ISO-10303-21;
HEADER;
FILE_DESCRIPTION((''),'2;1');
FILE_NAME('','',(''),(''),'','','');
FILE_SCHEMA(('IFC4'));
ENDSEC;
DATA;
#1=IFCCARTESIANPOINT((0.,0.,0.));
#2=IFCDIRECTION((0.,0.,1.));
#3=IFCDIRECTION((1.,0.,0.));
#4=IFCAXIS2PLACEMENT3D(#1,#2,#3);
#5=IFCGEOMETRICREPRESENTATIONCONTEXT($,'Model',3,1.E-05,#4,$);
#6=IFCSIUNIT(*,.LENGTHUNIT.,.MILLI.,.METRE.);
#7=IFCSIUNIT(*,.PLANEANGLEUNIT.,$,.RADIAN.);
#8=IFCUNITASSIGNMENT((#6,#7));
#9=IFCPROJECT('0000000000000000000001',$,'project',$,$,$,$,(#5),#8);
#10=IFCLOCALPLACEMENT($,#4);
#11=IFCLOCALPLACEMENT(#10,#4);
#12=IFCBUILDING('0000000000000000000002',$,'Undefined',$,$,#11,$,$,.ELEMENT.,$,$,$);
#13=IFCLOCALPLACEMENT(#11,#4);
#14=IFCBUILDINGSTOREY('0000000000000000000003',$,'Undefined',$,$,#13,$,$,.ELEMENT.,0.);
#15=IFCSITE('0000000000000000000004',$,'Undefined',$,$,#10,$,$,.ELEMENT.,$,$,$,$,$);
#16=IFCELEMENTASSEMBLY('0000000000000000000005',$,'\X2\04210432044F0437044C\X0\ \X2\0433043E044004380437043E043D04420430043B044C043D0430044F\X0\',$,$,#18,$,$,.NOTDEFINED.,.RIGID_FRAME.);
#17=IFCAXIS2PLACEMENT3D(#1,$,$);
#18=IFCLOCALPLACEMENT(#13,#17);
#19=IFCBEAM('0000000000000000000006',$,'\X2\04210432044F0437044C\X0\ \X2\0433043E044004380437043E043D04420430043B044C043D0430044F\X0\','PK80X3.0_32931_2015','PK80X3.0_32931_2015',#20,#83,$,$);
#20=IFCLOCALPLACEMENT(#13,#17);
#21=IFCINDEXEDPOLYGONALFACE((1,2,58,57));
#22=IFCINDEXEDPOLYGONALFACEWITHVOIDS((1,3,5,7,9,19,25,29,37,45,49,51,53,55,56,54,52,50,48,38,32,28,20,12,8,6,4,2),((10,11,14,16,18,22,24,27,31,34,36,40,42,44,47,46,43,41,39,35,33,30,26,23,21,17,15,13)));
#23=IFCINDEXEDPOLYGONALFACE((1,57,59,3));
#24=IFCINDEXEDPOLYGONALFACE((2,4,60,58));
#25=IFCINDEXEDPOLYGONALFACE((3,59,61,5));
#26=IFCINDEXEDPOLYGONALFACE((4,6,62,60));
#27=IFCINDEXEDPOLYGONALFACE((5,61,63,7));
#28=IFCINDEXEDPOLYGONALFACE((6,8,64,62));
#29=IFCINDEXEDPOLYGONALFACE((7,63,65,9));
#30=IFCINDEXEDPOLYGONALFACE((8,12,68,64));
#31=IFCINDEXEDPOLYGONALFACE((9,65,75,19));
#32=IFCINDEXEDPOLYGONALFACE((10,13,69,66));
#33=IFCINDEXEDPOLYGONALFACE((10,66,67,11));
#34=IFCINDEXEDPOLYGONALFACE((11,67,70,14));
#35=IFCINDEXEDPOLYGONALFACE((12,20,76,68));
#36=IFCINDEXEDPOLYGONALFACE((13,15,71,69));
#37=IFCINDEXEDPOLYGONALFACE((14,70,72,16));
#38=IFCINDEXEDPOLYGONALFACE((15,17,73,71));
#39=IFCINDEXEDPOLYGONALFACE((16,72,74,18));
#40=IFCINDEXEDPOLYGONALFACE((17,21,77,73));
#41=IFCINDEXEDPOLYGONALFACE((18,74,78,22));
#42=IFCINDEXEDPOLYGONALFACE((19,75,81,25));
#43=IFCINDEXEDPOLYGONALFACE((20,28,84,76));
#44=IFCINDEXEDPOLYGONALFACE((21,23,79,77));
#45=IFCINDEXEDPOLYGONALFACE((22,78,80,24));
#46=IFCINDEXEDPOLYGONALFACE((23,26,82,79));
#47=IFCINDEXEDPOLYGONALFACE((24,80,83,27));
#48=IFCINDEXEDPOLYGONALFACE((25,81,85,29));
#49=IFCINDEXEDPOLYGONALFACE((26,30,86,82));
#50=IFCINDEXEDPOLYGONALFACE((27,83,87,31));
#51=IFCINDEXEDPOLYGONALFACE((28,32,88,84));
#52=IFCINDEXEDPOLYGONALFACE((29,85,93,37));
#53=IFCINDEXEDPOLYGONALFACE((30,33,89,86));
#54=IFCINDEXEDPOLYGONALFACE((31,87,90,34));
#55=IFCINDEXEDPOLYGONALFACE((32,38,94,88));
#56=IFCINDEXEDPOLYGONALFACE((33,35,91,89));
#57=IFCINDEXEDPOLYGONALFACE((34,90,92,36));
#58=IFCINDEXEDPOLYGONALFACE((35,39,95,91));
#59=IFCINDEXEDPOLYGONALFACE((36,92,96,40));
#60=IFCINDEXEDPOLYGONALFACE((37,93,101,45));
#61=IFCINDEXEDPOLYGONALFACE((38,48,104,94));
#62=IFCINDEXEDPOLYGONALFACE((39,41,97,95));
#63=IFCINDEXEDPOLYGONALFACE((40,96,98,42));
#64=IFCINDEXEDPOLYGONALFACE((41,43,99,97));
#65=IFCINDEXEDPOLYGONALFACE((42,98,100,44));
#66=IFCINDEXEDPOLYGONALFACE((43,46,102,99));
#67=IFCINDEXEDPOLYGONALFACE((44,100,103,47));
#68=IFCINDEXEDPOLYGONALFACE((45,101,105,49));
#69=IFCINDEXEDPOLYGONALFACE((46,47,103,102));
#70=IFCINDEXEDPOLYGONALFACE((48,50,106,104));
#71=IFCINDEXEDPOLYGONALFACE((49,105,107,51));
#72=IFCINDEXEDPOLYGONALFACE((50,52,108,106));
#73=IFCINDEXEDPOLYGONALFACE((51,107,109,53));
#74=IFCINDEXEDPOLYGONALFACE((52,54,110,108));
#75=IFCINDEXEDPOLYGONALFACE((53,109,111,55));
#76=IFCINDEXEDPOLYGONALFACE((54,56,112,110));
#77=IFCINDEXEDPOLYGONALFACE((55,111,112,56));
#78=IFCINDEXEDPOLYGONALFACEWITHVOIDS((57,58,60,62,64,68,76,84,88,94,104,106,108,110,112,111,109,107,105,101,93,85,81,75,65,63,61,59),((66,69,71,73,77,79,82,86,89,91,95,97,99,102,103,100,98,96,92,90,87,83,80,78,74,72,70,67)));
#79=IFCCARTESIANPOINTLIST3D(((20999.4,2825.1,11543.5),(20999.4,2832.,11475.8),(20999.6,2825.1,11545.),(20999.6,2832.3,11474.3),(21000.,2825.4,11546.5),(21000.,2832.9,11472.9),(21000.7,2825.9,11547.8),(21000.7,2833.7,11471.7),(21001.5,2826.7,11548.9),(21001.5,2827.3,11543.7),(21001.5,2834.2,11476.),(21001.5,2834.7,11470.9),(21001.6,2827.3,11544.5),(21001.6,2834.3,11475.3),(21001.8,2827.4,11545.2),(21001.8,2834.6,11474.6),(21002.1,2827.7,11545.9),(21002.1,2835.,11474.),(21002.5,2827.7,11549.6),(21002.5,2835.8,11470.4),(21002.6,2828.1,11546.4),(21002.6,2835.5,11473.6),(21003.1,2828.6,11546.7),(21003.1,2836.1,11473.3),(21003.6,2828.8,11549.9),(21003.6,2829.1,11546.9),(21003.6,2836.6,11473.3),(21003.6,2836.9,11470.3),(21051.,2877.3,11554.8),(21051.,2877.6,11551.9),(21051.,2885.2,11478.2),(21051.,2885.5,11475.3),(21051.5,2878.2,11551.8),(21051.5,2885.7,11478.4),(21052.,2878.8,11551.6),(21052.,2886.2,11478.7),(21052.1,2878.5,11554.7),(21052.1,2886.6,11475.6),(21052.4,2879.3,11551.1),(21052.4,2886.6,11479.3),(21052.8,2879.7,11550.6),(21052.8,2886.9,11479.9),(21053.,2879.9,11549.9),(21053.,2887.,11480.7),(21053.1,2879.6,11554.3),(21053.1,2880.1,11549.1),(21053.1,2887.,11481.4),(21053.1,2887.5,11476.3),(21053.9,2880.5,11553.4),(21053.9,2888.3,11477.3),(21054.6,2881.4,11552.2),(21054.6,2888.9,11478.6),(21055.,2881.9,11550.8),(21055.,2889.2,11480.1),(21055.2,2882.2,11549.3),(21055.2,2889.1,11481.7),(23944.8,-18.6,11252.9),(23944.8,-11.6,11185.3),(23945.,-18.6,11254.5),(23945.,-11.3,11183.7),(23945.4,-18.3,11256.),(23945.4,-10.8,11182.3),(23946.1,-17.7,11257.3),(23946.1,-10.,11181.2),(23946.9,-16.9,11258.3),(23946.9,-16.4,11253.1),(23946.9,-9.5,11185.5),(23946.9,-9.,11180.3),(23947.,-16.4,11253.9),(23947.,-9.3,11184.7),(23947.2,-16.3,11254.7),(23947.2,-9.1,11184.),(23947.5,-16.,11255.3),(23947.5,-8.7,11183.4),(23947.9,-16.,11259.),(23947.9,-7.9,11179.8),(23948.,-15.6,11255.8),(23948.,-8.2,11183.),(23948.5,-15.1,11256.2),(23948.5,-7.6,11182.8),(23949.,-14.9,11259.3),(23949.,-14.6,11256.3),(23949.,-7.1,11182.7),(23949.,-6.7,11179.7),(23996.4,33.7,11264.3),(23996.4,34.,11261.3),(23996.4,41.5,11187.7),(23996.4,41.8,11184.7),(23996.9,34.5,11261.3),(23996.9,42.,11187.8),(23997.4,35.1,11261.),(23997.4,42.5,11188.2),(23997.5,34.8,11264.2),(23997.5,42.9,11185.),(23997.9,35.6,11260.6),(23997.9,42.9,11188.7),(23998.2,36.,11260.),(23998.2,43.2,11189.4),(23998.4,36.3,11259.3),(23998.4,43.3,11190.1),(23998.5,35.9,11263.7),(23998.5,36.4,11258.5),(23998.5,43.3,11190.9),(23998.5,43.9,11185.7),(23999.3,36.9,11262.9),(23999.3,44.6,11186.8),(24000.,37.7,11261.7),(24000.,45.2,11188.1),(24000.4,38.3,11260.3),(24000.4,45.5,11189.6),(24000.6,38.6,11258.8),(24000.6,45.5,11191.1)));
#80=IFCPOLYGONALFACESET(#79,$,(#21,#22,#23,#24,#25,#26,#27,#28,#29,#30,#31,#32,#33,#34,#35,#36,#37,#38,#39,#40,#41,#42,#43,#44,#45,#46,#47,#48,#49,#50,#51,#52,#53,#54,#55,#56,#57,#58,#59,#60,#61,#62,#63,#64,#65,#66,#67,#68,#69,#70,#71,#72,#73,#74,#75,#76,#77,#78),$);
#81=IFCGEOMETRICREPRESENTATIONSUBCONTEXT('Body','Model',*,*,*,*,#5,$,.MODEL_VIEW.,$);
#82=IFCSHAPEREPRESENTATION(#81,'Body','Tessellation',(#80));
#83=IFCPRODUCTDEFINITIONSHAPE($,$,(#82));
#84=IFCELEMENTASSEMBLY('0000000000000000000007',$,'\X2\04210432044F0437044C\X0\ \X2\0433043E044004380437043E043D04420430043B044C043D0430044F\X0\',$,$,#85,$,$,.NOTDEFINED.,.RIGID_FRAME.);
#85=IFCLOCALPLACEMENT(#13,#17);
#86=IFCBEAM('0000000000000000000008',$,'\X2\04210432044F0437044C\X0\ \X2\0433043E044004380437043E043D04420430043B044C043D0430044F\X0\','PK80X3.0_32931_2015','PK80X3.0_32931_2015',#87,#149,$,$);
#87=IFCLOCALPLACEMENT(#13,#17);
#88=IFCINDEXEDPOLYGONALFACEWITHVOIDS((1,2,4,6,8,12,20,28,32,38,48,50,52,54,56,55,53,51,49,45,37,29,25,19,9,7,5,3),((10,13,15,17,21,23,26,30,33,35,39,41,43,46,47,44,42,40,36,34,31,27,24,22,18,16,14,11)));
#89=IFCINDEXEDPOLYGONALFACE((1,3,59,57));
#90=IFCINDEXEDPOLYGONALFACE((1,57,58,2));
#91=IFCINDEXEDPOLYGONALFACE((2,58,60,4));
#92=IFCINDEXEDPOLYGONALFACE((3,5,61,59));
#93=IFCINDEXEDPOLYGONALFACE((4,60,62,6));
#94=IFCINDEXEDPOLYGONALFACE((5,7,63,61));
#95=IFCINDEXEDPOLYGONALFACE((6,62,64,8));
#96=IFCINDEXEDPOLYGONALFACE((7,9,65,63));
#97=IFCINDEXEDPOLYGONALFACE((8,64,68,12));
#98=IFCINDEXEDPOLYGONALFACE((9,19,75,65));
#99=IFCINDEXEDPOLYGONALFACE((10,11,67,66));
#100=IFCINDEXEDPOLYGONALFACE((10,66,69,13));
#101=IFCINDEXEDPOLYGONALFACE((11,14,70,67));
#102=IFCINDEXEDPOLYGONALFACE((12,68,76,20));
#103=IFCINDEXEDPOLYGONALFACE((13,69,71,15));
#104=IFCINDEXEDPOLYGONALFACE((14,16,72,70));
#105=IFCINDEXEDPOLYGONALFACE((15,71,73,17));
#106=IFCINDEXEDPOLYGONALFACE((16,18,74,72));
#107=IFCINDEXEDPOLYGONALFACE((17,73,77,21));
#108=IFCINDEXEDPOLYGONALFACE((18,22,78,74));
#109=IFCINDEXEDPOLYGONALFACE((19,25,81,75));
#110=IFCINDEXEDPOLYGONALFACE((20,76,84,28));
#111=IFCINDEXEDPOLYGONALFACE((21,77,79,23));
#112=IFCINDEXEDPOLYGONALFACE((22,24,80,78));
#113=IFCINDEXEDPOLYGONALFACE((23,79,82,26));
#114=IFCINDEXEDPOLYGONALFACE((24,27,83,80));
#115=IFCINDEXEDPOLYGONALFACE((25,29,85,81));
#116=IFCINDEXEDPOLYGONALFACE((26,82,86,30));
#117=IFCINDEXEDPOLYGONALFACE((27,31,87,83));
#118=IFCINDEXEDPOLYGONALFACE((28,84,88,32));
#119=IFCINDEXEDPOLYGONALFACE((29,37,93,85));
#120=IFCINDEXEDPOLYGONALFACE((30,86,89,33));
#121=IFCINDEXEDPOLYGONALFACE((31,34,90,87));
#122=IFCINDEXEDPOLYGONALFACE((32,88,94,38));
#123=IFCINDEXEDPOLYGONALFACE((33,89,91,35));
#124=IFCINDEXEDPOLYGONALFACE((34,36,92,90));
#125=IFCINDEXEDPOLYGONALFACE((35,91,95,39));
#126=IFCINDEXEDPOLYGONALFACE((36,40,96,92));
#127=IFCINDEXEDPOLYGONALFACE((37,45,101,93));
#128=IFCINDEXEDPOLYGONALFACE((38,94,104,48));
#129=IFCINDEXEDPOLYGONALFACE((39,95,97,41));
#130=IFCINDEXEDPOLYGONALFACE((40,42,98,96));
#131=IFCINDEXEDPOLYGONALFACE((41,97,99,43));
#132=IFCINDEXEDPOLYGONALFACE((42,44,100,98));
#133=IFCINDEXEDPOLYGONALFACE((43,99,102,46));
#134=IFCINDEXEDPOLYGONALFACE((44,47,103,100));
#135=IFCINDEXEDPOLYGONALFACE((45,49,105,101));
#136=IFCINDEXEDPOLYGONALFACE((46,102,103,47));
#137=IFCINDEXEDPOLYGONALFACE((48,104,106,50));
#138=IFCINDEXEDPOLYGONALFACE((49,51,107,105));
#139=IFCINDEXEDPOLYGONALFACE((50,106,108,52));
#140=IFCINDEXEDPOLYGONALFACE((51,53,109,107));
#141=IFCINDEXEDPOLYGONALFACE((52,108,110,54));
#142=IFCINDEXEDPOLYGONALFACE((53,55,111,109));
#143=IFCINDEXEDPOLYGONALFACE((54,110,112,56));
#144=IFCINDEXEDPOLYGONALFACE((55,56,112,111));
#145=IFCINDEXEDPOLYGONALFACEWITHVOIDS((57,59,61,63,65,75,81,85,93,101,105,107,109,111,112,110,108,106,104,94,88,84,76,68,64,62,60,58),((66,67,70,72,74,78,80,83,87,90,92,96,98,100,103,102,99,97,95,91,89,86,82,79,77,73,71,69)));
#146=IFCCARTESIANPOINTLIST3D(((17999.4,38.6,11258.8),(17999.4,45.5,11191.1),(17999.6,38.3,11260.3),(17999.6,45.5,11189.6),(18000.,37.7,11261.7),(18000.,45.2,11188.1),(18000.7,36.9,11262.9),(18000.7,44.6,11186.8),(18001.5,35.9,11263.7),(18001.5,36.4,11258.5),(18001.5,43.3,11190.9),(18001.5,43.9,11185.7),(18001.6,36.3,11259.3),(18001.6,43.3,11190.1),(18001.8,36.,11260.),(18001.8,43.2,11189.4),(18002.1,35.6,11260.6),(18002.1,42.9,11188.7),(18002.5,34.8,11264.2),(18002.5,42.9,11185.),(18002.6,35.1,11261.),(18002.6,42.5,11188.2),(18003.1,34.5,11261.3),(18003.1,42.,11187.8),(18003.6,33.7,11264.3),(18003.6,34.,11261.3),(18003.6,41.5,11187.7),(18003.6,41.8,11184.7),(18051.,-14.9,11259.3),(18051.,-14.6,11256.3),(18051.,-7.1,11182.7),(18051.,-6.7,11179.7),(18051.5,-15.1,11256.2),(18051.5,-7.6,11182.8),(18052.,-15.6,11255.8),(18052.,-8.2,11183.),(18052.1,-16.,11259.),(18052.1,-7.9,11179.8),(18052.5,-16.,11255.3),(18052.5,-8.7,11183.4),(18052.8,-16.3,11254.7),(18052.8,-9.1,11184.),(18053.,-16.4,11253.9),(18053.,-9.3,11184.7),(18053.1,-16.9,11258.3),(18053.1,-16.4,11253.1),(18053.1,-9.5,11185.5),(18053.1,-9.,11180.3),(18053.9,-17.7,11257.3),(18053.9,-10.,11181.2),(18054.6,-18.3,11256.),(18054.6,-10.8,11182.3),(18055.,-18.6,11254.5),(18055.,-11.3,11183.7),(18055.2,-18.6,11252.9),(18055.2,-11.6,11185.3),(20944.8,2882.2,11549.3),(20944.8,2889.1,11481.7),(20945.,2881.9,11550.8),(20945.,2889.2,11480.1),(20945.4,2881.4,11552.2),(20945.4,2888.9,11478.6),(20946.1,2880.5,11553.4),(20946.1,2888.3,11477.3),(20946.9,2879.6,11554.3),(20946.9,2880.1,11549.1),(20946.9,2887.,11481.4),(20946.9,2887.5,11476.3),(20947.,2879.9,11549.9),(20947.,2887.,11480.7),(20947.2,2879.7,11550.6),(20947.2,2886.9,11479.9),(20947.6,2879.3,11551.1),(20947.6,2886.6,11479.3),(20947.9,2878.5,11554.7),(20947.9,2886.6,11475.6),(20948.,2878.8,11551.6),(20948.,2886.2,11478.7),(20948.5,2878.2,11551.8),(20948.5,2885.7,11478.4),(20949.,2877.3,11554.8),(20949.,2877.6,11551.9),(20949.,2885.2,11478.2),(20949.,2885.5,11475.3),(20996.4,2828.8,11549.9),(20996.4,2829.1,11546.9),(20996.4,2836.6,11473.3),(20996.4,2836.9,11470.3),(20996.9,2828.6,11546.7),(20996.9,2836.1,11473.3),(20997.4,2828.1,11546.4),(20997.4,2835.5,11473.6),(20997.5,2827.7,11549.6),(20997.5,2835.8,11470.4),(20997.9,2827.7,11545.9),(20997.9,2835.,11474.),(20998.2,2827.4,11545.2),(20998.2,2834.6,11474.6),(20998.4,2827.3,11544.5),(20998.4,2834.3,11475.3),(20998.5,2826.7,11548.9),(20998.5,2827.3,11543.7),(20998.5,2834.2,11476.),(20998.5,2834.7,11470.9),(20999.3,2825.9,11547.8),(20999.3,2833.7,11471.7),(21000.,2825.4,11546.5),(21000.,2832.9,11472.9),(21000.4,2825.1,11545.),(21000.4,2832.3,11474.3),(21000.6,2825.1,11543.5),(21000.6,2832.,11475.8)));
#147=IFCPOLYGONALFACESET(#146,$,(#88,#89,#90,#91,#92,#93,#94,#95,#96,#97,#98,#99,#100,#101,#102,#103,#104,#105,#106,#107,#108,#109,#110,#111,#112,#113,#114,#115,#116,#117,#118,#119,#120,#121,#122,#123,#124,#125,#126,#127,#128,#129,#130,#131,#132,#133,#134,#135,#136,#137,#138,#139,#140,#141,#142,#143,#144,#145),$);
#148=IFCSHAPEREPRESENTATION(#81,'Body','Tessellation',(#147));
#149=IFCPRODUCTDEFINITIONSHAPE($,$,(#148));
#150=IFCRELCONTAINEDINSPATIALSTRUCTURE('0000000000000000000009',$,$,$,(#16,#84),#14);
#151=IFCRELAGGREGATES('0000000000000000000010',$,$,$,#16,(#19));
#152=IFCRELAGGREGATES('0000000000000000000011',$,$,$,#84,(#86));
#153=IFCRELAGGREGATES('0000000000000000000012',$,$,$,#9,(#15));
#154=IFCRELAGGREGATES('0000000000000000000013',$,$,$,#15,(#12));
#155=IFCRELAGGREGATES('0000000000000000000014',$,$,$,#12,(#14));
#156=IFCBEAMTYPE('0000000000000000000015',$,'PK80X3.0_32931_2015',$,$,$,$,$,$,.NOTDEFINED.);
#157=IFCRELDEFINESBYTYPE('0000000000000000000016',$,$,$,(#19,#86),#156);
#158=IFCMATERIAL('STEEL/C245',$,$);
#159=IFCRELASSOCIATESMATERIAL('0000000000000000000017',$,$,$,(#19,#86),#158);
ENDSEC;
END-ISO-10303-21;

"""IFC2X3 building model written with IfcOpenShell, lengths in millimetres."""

from ifc_helpers import new_model, si_unit, frame, origin_with_axes, origin_2d_with_axis, place, context, subcontext, project, spatial, hollow_rectangle, extrude, material, type_object, element, aggregate, save


model = new_model("IFC2X3")

# Units and contexts
model_context = context("Model", 3, precision=1e-05, world=origin_with_axes())
body_context = subcontext(model_context, "Body", "Model", "MODEL_VIEW")
ifc_project = project(units=[si_unit("LENGTHUNIT", "METRE", prefix="MILLI"), si_unit("PLANEANGLEUNIT", "RADIAN")], contexts=[model_context])

# Site, building, storey
site_placement = place(None, origin_with_axes())
site = spatial("IfcSite", under=ifc_project, at=site_placement, Name="Undefined", CompositionType="ELEMENT")
building_placement = place(site_placement, origin_with_axes())
building = spatial("IfcBuilding", under=site, at=building_placement, Name="Undefined", CompositionType="ELEMENT")
storey_placement = place(building_placement, origin_with_axes())
storey = spatial("IfcBuildingStorey", under=building, at=storey_placement, Name="Undefined", CompositionType="ELEMENT", Elevation=0.0)

# Element assemblies, beams
ifc_material_1 = material(Name="STEEL/C245")
assembly_1_placement = place(storey_placement, origin_with_axes())
assembly_1 = element("IfcElementAssembly", 1, at=assembly_1_placement, inside=storey, Name="Связь горизонтальная", AssemblyPlace="NOTDEFINED", PredefinedType="RIGID_FRAME")
beam_type_1 = type_object("IfcBeamType", Name="PK80X3.0_32931_2015", PredefinedType="NOTDEFINED")
beam_1_placement = place(assembly_1_placement, frame((23972.7, 13.5, 11222.0), z_axis=(0.0, -0.101645, 0.994821), x_axis=(-0.717617, 0.69283, 0.070789)))
beam_1 = element("IfcBeam", 2, at=beam_1_placement, type_object=beam_type_1, material=ifc_material_1, Name="Связь горизонтальная", Description="PK80X3.0_32931_2015", ObjectType="PK80X3.0_32931_2015", context=body_context, shape_type="SweptSolid", body=[
    extrude(hollow_rectangle(XDim=80.0, YDim=80.0, WallThickness=3.0, InnerFilletRadius=3.0, OuterFilletRadius=6.0, at=origin_2d_with_axis()), frame((4104.4, 0.0, 0.0), z_axis=(-1.0, 0.0, 0.0), x_axis=(0.0, -1.0, 0.0)), (0.0, 0.0, 1.0), 4104.4),
])
aggregate(assembly_1, [beam_1])
assembly_2_placement = place(storey_placement, origin_with_axes())
assembly_2 = element("IfcElementAssembly", 3, at=assembly_2_placement, inside=storey, Name="Связь горизонтальная", AssemblyPlace="NOTDEFINED", PredefinedType="RIGID_FRAME")
beam_2_placement = place(assembly_2_placement, frame((18027.3, 13.5, 11222.0), z_axis=(0.0, -0.101645, 0.994821), x_axis=(0.717617, 0.69283, 0.070789)))
beam_2 = element("IfcBeam", 4, at=beam_2_placement, type_object=beam_type_1, material=ifc_material_1, Name="Связь горизонтальная", Description="PK80X3.0_32931_2015", ObjectType="PK80X3.0_32931_2015", context=body_context, shape_type="SweptSolid", body=[
    extrude(hollow_rectangle(XDim=80.0, YDim=80.0, WallThickness=3.0, InnerFilletRadius=3.0, OuterFilletRadius=6.0, at=origin_2d_with_axis()), frame((4104.4, 0.0, 0.0), z_axis=(-1.0, 0.0, 0.0), x_axis=(0.0, -1.0, 0.0)), (0.0, 0.0, 1.0), 4104.4),
])
aggregate(assembly_2, [beam_2])

save(model, "model.ifc")
